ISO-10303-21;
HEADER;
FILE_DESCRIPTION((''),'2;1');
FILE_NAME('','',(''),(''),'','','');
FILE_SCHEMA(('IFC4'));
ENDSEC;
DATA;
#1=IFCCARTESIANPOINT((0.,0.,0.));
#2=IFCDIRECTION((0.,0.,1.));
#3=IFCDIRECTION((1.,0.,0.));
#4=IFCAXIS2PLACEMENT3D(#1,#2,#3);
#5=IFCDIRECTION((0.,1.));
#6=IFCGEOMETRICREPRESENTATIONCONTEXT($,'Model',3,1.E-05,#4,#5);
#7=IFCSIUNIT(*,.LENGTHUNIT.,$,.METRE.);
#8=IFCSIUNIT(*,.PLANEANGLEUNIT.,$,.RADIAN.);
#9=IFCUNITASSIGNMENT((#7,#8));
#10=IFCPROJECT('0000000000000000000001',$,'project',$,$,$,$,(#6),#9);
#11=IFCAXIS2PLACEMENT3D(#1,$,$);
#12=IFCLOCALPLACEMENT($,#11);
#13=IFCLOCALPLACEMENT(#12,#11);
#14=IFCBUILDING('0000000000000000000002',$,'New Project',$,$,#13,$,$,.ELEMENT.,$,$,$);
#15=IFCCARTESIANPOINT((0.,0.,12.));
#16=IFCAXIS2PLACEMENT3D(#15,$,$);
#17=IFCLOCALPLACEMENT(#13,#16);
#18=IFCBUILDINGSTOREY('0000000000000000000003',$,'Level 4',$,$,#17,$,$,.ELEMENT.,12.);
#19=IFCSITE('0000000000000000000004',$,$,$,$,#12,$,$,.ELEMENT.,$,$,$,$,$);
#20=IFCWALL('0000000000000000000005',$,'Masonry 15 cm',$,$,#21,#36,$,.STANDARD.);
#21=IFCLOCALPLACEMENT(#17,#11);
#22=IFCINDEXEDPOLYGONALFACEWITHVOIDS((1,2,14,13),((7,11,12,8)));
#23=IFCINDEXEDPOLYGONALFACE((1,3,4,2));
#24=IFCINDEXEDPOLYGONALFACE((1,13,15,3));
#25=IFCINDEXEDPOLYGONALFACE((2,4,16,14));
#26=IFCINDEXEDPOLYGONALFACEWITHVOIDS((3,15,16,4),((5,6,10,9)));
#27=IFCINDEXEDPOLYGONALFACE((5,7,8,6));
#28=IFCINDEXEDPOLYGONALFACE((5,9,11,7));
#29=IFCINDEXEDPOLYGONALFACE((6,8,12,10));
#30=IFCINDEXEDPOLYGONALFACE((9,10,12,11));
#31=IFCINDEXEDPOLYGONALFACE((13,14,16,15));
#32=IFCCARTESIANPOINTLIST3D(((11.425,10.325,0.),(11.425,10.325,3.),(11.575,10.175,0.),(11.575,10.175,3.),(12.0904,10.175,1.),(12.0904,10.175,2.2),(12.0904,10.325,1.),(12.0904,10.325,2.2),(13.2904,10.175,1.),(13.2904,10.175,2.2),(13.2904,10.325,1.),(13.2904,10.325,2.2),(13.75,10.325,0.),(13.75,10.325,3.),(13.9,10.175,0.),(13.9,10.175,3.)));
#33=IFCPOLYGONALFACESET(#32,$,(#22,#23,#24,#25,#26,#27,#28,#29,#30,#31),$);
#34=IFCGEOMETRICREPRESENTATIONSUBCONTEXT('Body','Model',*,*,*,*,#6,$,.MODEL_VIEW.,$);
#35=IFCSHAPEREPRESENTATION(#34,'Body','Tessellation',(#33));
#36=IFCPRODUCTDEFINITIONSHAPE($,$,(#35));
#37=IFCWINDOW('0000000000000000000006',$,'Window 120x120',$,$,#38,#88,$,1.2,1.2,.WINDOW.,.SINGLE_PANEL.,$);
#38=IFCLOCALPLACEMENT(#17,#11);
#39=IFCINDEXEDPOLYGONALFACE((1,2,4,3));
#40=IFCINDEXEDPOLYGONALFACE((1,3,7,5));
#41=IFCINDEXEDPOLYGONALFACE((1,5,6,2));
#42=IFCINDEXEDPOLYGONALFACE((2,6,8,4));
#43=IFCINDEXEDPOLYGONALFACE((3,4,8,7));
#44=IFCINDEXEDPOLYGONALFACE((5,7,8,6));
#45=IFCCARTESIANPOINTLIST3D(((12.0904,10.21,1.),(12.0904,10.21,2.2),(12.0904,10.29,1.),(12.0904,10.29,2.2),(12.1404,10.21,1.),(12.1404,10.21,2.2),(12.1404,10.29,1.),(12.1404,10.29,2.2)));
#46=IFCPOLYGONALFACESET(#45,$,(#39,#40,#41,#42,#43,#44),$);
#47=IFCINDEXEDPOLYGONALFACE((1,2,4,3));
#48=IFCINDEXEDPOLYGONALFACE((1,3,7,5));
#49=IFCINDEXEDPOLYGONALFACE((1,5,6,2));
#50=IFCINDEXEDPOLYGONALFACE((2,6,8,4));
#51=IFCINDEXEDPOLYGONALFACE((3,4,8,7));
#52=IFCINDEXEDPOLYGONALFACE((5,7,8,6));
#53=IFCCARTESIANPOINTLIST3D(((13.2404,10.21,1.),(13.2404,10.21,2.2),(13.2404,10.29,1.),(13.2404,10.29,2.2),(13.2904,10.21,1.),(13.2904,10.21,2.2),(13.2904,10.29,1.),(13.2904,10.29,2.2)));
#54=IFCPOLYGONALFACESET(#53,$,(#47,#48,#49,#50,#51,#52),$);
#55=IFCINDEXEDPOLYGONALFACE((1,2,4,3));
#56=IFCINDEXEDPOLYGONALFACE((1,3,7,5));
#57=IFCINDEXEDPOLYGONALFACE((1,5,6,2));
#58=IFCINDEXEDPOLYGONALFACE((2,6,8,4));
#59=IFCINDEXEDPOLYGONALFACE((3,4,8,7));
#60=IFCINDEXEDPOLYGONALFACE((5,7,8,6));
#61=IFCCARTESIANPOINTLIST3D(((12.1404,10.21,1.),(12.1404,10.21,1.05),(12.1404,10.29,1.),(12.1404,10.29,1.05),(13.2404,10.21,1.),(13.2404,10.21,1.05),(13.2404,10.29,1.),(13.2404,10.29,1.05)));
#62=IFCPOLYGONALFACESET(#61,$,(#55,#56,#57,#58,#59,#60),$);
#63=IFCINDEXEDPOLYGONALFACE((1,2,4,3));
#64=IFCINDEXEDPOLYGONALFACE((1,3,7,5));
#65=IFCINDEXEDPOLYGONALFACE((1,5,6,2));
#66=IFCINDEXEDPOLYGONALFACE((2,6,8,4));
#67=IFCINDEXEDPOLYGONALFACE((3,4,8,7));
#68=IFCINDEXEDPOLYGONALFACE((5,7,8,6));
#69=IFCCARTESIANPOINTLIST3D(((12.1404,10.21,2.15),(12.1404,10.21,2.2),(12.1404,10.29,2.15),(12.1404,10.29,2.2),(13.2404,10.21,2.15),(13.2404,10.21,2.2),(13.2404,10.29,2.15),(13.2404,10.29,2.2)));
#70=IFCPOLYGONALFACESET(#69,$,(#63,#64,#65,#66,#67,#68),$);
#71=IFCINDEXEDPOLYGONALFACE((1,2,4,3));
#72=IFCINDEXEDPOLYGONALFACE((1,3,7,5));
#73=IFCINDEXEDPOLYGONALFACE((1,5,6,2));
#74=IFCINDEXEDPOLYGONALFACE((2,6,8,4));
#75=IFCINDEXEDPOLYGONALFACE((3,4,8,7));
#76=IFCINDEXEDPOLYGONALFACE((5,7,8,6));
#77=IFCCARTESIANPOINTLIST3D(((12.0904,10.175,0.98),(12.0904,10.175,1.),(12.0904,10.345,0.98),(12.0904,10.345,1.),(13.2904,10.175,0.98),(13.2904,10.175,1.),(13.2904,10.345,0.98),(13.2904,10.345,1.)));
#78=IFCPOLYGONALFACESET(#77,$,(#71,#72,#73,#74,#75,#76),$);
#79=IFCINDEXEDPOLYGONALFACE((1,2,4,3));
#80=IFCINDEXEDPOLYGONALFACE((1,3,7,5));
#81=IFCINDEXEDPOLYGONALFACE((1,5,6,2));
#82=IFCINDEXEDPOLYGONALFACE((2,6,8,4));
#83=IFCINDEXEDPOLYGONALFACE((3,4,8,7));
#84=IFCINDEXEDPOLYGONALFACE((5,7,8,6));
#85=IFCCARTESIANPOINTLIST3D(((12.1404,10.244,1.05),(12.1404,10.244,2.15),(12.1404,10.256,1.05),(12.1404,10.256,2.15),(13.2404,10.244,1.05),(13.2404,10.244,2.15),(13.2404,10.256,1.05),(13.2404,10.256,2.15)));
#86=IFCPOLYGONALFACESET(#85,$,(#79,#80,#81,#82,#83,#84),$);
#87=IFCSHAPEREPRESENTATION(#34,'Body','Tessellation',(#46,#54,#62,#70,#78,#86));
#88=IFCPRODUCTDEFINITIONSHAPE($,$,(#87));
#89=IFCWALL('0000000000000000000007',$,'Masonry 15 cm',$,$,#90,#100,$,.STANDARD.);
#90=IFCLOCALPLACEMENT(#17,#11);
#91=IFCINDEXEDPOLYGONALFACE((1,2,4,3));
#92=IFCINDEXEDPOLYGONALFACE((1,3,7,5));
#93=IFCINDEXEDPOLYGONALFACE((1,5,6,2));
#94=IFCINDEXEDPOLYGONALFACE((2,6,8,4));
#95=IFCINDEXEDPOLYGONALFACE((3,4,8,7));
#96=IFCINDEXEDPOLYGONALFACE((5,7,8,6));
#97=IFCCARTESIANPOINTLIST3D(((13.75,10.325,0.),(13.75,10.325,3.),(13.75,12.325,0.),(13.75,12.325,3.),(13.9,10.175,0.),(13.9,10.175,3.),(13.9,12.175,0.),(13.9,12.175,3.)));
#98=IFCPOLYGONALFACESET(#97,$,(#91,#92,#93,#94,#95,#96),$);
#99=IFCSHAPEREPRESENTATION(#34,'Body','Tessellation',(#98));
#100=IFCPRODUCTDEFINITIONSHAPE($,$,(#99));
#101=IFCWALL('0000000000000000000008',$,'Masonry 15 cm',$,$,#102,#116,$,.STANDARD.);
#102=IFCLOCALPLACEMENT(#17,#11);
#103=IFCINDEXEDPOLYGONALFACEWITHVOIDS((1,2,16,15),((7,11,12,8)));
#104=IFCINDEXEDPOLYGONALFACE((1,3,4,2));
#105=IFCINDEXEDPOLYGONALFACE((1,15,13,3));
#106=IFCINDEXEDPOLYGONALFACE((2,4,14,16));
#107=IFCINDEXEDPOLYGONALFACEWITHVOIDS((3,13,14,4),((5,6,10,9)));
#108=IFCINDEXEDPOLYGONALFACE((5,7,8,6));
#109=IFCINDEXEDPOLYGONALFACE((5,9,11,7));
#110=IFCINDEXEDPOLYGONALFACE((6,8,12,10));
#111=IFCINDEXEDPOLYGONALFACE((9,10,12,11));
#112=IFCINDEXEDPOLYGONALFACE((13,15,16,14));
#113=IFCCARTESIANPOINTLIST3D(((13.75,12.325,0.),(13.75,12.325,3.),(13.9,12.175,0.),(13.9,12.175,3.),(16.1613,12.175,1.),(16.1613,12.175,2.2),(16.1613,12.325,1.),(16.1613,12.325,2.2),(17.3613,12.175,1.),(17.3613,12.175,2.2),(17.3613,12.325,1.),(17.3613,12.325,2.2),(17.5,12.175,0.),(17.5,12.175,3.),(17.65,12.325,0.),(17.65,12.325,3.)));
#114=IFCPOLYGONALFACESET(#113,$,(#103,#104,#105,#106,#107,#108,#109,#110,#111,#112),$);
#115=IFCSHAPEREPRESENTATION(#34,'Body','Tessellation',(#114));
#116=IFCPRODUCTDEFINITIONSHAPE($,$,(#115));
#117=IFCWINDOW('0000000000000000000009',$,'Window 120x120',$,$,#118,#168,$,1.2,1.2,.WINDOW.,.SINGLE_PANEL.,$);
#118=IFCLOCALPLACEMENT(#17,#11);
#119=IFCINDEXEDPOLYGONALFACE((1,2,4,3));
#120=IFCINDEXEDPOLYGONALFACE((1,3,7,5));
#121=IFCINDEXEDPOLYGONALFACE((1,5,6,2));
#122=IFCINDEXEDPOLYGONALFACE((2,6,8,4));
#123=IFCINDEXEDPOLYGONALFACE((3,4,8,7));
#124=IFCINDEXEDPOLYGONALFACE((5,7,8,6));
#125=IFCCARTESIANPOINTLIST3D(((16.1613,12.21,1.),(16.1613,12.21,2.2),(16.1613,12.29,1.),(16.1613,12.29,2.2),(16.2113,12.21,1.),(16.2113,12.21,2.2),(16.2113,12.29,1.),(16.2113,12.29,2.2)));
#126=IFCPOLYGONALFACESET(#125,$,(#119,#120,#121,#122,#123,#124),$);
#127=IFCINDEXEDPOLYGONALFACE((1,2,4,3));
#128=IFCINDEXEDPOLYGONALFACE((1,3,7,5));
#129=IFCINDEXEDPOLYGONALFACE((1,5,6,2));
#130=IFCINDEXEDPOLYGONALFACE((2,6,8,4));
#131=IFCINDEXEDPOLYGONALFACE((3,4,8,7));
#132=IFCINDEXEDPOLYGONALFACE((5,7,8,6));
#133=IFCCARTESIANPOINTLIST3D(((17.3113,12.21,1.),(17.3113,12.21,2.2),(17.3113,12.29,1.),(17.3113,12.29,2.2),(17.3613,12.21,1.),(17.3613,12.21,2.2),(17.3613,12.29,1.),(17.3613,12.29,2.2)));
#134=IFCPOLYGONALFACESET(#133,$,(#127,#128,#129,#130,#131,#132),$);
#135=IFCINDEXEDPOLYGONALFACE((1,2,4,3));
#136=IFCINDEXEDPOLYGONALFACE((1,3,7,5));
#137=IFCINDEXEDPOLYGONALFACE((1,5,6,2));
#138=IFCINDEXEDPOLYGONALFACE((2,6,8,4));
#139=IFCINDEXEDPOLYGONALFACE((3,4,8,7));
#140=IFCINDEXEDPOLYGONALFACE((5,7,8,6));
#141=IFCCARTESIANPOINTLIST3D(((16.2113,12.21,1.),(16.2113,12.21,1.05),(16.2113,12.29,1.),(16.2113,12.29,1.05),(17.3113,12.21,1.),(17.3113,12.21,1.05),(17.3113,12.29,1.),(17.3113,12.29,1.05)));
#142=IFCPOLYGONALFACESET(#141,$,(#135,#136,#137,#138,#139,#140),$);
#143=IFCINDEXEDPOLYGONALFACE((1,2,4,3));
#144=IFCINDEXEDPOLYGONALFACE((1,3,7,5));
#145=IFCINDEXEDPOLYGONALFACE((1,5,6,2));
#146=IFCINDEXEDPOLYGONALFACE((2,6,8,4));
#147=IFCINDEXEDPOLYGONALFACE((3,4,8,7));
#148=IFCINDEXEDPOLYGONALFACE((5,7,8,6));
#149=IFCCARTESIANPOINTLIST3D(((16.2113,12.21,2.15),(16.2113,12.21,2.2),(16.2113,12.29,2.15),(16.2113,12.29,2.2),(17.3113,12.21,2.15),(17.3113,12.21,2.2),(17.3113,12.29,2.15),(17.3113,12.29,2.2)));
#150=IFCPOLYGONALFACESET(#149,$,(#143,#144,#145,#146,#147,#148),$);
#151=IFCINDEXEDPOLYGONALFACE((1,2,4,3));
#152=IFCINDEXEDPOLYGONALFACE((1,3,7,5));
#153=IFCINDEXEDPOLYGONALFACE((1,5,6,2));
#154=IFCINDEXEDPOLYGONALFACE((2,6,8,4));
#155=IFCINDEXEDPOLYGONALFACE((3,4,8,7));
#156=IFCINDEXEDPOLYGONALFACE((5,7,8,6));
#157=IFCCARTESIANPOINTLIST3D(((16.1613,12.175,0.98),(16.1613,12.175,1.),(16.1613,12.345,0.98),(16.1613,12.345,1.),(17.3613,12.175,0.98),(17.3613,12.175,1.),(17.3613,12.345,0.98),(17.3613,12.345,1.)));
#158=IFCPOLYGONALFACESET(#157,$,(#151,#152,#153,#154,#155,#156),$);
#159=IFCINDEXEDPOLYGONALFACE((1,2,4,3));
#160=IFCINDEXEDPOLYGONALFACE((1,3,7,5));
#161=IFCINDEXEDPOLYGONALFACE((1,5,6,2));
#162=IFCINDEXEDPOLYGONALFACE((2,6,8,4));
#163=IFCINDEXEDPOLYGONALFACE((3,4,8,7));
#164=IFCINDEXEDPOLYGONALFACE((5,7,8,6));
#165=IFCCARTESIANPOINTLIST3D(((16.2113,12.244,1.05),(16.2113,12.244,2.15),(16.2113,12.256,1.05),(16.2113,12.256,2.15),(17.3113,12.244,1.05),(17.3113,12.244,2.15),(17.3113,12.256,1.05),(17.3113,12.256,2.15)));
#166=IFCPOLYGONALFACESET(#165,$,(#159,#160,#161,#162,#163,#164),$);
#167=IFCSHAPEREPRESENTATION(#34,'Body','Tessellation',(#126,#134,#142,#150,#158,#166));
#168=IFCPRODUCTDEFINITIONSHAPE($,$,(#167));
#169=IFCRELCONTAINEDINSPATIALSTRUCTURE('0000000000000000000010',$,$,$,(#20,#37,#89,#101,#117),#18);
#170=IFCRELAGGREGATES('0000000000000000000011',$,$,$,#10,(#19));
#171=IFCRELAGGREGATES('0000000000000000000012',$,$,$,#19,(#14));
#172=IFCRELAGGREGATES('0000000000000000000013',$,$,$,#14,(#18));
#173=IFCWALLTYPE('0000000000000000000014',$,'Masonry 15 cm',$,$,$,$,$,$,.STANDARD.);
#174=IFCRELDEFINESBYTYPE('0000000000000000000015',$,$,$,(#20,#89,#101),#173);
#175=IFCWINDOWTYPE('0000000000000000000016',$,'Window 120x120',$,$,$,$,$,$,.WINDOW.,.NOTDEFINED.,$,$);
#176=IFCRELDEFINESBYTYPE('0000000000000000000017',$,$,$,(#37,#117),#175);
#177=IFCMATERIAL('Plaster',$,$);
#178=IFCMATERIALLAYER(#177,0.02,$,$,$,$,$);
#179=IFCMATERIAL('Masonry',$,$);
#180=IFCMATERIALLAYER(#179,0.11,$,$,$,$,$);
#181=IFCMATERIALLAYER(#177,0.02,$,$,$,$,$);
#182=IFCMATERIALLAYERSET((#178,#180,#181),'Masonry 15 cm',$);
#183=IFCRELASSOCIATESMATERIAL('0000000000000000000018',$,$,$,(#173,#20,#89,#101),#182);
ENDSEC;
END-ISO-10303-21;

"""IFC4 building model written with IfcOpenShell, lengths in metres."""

from ifc_helpers import new_model, si_unit, direction, frame, frame_2d, origin, origin_with_axes, place, context, subcontext, project, spatial, polyline, rectangle, outline, extrude, material, layer, layer_set, layer_usage, type_object, element, fill, save


model = new_model("IFC4")

# Units and contexts
model_context = context("Model", 3, precision=1e-05, world=origin_with_axes(), true_north=direction((0.0, 1.0)))
body_context = subcontext(model_context, "Body", "Model", "MODEL_VIEW")
ifc_project = project(units=[si_unit("LENGTHUNIT", "METRE"), si_unit("PLANEANGLEUNIT", "RADIAN")], contexts=[model_context])

# Site, building, storey
site_placement = place(None, origin())
site = spatial("IfcSite", under=ifc_project, at=site_placement, CompositionType="ELEMENT")
building_placement = place(site_placement, origin())
building = spatial("IfcBuilding", under=site, at=building_placement, Name="New Project", CompositionType="ELEMENT")
storey_placement = place(building_placement, frame((0.0, 0.0, 12.0)))
storey = spatial("IfcBuildingStorey", under=building, at=storey_placement, Name="Level 4", CompositionType="ELEMENT", Elevation=12.0)

# Shared definitions
ifc_material_1 = material(Name="Plaster")
ifc_layer_1 = layer(ifc_material_1, 0.02)
ifc_material_2 = material(Name="Masonry")
ifc_layer_2 = layer(ifc_material_2, 0.11)
ifc_layer_3 = layer(ifc_material_1, 0.02)
ifc_layer_set_1 = layer_set([ifc_layer_1, ifc_layer_2, ifc_layer_3], Name="Masonry 15 cm")
ifc_layer_usage_1 = layer_usage(ifc_layer_set_1, "AXIS2", "NEGATIVE", 0.075)
wall_type_1 = type_object("IfcWallType", Name="Masonry 15 cm", PredefinedType="STANDARD", material=ifc_layer_set_1)
window_type = type_object("IfcWindowType", Name="Window 120x120", PartitioningType="NOTDEFINED", PredefinedType="WINDOW")

# Wall, opening, window
wall_1_placement = place(storey_placement, frame((11.5, 10.25, 0.0)))
wall_1 = element("IfcWall", 1, at=wall_1_placement, inside=storey, type_object=wall_type_1, material=ifc_layer_usage_1, Name="Masonry 15 cm", PredefinedType="STANDARD", context=body_context, shape_type="SweptSolid", body=[
    extrude(outline(polyline([(0.075, -0.075), (2.4, -0.075), (2.25, 0.075), (-0.075, 0.075), (0.075, -0.075)])), origin(), (0.0, 0.0, 1.0), 3.0),
])
opening_1_placement = place(wall_1_placement, frame((0.5904, 0.0, 1.0)))
opening_1 = element("IfcOpeningElement", 2, at=opening_1_placement, cuts=wall_1, PredefinedType="OPENING", context=body_context, shape_type="SweptSolid", body=[
    extrude(rectangle(XDim=1.2, YDim=0.25, at=frame_2d((0.6, 0.0))), origin(), (0.0, 0.0, 1.0), 1.2),
])
window_1_placement = place(opening_1_placement, origin())
window_1 = element("IfcWindow", 3, at=window_1_placement, inside=storey, type_object=window_type, Name="Window 120x120", OverallHeight=1.2, OverallWidth=1.2, PartitioningType="SINGLE_PANEL", PredefinedType="WINDOW", context=body_context, shape_type="SweptSolid", body=[
    extrude(outline(polyline([(0.0, -0.04), (0.05, -0.04), (0.05, 0.04), (0.0, 0.04), (0.0, -0.04)])), origin(), (0.0, 0.0, 1.0), 1.2),
    extrude(outline(polyline([(1.15, -0.04), (1.2, -0.04), (1.2, 0.04), (1.15, 0.04), (1.15, -0.04)])), origin(), (0.0, 0.0, 1.0), 1.2),
    extrude(outline(polyline([(0.05, -0.04), (1.15, -0.04), (1.15, 0.04), (0.05, 0.04), (0.05, -0.04)])), origin(), (0.0, 0.0, 1.0), 0.05),
    extrude(outline(polyline([(0.05, -0.04), (1.15, -0.04), (1.15, 0.04), (0.05, 0.04), (0.05, -0.04)])), frame((0.0, 0.0, 1.15)), (0.0, 0.0, 1.0), 0.05),
    extrude(outline(polyline([(0.0, -0.075), (1.2, -0.075), (1.2, 0.095), (0.0, 0.095), (0.0, -0.075)])), frame((0.0, 0.0, -0.02)), (0.0, 0.0, 1.0), 0.02),
    extrude(outline(polyline([(0.05, -0.006), (1.15, -0.006), (1.15, 0.006), (0.05, 0.006), (0.05, -0.006)])), frame((0.0, 0.0, 0.05)), (0.0, 0.0, 1.0), 1.1),
])
fill(opening_1, window_1)

# Wall
wall_2_placement = place(storey_placement, frame((13.825, 10.25, 0.0), z_axis=(0.0, 0.0, 1.0), x_axis=(0.0, 1.0, 0.0)))
element("IfcWall", 4, at=wall_2_placement, inside=storey, type_object=wall_type_1, material=ifc_layer_usage_1, Name="Masonry 15 cm", PredefinedType="STANDARD", context=body_context, shape_type="SweptSolid", body=[
    extrude(outline(polyline([(-0.075, -0.075), (1.925, -0.075), (2.075, 0.075), (0.075, 0.075), (-0.075, -0.075)])), origin(), (0.0, 0.0, 1.0), 3.0),
])

# Wall, opening, window
wall_3_placement = place(storey_placement, frame((13.825, 12.25, 0.0)))
wall_3 = element("IfcWall", 5, at=wall_3_placement, inside=storey, type_object=wall_type_1, material=ifc_layer_usage_1, Name="Masonry 15 cm", PredefinedType="STANDARD", context=body_context, shape_type="SweptSolid", body=[
    extrude(outline(polyline([(0.075, -0.075), (3.675, -0.075), (3.825, 0.075), (-0.075, 0.075), (0.075, -0.075)])), origin(), (0.0, 0.0, 1.0), 3.0),
])
opening_2_placement = place(wall_3_placement, frame((2.3363, 0.0, 1.0)))
opening_2 = element("IfcOpeningElement", 6, at=opening_2_placement, cuts=wall_3, PredefinedType="OPENING", context=body_context, shape_type="SweptSolid", body=[
    extrude(rectangle(XDim=1.2, YDim=0.25, at=frame_2d((0.6, 0.0))), origin(), (0.0, 0.0, 1.0), 1.2),
])
window_2_placement = place(opening_2_placement, origin())
window_2 = element("IfcWindow", 7, at=window_2_placement, inside=storey, type_object=window_type, Name="Window 120x120", OverallHeight=1.2, OverallWidth=1.2, PartitioningType="SINGLE_PANEL", PredefinedType="WINDOW", context=body_context, shape_type="SweptSolid", body=[
    extrude(outline(polyline([(0.0, -0.04), (0.05, -0.04), (0.05, 0.04), (0.0, 0.04), (0.0, -0.04)])), origin(), (0.0, 0.0, 1.0), 1.2),
    extrude(outline(polyline([(1.15, -0.04), (1.2, -0.04), (1.2, 0.04), (1.15, 0.04), (1.15, -0.04)])), origin(), (0.0, 0.0, 1.0), 1.2),
    extrude(outline(polyline([(0.05, -0.04), (1.15, -0.04), (1.15, 0.04), (0.05, 0.04), (0.05, -0.04)])), origin(), (0.0, 0.0, 1.0), 0.05),
    extrude(outline(polyline([(0.05, -0.04), (1.15, -0.04), (1.15, 0.04), (0.05, 0.04), (0.05, -0.04)])), frame((0.0, 0.0, 1.15)), (0.0, 0.0, 1.0), 0.05),
    extrude(outline(polyline([(0.0, -0.075), (1.2, -0.075), (1.2, 0.095), (0.0, 0.095), (0.0, -0.075)])), frame((0.0, 0.0, -0.02)), (0.0, 0.0, 1.0), 0.02),
    extrude(outline(polyline([(0.05, -0.006), (1.15, -0.006), (1.15, 0.006), (0.05, 0.006), (0.05, -0.006)])), frame((0.0, 0.0, 0.05)), (0.0, 0.0, 1.0), 1.1),
])
fill(opening_2, window_2)

save(model, "model.ifc")
